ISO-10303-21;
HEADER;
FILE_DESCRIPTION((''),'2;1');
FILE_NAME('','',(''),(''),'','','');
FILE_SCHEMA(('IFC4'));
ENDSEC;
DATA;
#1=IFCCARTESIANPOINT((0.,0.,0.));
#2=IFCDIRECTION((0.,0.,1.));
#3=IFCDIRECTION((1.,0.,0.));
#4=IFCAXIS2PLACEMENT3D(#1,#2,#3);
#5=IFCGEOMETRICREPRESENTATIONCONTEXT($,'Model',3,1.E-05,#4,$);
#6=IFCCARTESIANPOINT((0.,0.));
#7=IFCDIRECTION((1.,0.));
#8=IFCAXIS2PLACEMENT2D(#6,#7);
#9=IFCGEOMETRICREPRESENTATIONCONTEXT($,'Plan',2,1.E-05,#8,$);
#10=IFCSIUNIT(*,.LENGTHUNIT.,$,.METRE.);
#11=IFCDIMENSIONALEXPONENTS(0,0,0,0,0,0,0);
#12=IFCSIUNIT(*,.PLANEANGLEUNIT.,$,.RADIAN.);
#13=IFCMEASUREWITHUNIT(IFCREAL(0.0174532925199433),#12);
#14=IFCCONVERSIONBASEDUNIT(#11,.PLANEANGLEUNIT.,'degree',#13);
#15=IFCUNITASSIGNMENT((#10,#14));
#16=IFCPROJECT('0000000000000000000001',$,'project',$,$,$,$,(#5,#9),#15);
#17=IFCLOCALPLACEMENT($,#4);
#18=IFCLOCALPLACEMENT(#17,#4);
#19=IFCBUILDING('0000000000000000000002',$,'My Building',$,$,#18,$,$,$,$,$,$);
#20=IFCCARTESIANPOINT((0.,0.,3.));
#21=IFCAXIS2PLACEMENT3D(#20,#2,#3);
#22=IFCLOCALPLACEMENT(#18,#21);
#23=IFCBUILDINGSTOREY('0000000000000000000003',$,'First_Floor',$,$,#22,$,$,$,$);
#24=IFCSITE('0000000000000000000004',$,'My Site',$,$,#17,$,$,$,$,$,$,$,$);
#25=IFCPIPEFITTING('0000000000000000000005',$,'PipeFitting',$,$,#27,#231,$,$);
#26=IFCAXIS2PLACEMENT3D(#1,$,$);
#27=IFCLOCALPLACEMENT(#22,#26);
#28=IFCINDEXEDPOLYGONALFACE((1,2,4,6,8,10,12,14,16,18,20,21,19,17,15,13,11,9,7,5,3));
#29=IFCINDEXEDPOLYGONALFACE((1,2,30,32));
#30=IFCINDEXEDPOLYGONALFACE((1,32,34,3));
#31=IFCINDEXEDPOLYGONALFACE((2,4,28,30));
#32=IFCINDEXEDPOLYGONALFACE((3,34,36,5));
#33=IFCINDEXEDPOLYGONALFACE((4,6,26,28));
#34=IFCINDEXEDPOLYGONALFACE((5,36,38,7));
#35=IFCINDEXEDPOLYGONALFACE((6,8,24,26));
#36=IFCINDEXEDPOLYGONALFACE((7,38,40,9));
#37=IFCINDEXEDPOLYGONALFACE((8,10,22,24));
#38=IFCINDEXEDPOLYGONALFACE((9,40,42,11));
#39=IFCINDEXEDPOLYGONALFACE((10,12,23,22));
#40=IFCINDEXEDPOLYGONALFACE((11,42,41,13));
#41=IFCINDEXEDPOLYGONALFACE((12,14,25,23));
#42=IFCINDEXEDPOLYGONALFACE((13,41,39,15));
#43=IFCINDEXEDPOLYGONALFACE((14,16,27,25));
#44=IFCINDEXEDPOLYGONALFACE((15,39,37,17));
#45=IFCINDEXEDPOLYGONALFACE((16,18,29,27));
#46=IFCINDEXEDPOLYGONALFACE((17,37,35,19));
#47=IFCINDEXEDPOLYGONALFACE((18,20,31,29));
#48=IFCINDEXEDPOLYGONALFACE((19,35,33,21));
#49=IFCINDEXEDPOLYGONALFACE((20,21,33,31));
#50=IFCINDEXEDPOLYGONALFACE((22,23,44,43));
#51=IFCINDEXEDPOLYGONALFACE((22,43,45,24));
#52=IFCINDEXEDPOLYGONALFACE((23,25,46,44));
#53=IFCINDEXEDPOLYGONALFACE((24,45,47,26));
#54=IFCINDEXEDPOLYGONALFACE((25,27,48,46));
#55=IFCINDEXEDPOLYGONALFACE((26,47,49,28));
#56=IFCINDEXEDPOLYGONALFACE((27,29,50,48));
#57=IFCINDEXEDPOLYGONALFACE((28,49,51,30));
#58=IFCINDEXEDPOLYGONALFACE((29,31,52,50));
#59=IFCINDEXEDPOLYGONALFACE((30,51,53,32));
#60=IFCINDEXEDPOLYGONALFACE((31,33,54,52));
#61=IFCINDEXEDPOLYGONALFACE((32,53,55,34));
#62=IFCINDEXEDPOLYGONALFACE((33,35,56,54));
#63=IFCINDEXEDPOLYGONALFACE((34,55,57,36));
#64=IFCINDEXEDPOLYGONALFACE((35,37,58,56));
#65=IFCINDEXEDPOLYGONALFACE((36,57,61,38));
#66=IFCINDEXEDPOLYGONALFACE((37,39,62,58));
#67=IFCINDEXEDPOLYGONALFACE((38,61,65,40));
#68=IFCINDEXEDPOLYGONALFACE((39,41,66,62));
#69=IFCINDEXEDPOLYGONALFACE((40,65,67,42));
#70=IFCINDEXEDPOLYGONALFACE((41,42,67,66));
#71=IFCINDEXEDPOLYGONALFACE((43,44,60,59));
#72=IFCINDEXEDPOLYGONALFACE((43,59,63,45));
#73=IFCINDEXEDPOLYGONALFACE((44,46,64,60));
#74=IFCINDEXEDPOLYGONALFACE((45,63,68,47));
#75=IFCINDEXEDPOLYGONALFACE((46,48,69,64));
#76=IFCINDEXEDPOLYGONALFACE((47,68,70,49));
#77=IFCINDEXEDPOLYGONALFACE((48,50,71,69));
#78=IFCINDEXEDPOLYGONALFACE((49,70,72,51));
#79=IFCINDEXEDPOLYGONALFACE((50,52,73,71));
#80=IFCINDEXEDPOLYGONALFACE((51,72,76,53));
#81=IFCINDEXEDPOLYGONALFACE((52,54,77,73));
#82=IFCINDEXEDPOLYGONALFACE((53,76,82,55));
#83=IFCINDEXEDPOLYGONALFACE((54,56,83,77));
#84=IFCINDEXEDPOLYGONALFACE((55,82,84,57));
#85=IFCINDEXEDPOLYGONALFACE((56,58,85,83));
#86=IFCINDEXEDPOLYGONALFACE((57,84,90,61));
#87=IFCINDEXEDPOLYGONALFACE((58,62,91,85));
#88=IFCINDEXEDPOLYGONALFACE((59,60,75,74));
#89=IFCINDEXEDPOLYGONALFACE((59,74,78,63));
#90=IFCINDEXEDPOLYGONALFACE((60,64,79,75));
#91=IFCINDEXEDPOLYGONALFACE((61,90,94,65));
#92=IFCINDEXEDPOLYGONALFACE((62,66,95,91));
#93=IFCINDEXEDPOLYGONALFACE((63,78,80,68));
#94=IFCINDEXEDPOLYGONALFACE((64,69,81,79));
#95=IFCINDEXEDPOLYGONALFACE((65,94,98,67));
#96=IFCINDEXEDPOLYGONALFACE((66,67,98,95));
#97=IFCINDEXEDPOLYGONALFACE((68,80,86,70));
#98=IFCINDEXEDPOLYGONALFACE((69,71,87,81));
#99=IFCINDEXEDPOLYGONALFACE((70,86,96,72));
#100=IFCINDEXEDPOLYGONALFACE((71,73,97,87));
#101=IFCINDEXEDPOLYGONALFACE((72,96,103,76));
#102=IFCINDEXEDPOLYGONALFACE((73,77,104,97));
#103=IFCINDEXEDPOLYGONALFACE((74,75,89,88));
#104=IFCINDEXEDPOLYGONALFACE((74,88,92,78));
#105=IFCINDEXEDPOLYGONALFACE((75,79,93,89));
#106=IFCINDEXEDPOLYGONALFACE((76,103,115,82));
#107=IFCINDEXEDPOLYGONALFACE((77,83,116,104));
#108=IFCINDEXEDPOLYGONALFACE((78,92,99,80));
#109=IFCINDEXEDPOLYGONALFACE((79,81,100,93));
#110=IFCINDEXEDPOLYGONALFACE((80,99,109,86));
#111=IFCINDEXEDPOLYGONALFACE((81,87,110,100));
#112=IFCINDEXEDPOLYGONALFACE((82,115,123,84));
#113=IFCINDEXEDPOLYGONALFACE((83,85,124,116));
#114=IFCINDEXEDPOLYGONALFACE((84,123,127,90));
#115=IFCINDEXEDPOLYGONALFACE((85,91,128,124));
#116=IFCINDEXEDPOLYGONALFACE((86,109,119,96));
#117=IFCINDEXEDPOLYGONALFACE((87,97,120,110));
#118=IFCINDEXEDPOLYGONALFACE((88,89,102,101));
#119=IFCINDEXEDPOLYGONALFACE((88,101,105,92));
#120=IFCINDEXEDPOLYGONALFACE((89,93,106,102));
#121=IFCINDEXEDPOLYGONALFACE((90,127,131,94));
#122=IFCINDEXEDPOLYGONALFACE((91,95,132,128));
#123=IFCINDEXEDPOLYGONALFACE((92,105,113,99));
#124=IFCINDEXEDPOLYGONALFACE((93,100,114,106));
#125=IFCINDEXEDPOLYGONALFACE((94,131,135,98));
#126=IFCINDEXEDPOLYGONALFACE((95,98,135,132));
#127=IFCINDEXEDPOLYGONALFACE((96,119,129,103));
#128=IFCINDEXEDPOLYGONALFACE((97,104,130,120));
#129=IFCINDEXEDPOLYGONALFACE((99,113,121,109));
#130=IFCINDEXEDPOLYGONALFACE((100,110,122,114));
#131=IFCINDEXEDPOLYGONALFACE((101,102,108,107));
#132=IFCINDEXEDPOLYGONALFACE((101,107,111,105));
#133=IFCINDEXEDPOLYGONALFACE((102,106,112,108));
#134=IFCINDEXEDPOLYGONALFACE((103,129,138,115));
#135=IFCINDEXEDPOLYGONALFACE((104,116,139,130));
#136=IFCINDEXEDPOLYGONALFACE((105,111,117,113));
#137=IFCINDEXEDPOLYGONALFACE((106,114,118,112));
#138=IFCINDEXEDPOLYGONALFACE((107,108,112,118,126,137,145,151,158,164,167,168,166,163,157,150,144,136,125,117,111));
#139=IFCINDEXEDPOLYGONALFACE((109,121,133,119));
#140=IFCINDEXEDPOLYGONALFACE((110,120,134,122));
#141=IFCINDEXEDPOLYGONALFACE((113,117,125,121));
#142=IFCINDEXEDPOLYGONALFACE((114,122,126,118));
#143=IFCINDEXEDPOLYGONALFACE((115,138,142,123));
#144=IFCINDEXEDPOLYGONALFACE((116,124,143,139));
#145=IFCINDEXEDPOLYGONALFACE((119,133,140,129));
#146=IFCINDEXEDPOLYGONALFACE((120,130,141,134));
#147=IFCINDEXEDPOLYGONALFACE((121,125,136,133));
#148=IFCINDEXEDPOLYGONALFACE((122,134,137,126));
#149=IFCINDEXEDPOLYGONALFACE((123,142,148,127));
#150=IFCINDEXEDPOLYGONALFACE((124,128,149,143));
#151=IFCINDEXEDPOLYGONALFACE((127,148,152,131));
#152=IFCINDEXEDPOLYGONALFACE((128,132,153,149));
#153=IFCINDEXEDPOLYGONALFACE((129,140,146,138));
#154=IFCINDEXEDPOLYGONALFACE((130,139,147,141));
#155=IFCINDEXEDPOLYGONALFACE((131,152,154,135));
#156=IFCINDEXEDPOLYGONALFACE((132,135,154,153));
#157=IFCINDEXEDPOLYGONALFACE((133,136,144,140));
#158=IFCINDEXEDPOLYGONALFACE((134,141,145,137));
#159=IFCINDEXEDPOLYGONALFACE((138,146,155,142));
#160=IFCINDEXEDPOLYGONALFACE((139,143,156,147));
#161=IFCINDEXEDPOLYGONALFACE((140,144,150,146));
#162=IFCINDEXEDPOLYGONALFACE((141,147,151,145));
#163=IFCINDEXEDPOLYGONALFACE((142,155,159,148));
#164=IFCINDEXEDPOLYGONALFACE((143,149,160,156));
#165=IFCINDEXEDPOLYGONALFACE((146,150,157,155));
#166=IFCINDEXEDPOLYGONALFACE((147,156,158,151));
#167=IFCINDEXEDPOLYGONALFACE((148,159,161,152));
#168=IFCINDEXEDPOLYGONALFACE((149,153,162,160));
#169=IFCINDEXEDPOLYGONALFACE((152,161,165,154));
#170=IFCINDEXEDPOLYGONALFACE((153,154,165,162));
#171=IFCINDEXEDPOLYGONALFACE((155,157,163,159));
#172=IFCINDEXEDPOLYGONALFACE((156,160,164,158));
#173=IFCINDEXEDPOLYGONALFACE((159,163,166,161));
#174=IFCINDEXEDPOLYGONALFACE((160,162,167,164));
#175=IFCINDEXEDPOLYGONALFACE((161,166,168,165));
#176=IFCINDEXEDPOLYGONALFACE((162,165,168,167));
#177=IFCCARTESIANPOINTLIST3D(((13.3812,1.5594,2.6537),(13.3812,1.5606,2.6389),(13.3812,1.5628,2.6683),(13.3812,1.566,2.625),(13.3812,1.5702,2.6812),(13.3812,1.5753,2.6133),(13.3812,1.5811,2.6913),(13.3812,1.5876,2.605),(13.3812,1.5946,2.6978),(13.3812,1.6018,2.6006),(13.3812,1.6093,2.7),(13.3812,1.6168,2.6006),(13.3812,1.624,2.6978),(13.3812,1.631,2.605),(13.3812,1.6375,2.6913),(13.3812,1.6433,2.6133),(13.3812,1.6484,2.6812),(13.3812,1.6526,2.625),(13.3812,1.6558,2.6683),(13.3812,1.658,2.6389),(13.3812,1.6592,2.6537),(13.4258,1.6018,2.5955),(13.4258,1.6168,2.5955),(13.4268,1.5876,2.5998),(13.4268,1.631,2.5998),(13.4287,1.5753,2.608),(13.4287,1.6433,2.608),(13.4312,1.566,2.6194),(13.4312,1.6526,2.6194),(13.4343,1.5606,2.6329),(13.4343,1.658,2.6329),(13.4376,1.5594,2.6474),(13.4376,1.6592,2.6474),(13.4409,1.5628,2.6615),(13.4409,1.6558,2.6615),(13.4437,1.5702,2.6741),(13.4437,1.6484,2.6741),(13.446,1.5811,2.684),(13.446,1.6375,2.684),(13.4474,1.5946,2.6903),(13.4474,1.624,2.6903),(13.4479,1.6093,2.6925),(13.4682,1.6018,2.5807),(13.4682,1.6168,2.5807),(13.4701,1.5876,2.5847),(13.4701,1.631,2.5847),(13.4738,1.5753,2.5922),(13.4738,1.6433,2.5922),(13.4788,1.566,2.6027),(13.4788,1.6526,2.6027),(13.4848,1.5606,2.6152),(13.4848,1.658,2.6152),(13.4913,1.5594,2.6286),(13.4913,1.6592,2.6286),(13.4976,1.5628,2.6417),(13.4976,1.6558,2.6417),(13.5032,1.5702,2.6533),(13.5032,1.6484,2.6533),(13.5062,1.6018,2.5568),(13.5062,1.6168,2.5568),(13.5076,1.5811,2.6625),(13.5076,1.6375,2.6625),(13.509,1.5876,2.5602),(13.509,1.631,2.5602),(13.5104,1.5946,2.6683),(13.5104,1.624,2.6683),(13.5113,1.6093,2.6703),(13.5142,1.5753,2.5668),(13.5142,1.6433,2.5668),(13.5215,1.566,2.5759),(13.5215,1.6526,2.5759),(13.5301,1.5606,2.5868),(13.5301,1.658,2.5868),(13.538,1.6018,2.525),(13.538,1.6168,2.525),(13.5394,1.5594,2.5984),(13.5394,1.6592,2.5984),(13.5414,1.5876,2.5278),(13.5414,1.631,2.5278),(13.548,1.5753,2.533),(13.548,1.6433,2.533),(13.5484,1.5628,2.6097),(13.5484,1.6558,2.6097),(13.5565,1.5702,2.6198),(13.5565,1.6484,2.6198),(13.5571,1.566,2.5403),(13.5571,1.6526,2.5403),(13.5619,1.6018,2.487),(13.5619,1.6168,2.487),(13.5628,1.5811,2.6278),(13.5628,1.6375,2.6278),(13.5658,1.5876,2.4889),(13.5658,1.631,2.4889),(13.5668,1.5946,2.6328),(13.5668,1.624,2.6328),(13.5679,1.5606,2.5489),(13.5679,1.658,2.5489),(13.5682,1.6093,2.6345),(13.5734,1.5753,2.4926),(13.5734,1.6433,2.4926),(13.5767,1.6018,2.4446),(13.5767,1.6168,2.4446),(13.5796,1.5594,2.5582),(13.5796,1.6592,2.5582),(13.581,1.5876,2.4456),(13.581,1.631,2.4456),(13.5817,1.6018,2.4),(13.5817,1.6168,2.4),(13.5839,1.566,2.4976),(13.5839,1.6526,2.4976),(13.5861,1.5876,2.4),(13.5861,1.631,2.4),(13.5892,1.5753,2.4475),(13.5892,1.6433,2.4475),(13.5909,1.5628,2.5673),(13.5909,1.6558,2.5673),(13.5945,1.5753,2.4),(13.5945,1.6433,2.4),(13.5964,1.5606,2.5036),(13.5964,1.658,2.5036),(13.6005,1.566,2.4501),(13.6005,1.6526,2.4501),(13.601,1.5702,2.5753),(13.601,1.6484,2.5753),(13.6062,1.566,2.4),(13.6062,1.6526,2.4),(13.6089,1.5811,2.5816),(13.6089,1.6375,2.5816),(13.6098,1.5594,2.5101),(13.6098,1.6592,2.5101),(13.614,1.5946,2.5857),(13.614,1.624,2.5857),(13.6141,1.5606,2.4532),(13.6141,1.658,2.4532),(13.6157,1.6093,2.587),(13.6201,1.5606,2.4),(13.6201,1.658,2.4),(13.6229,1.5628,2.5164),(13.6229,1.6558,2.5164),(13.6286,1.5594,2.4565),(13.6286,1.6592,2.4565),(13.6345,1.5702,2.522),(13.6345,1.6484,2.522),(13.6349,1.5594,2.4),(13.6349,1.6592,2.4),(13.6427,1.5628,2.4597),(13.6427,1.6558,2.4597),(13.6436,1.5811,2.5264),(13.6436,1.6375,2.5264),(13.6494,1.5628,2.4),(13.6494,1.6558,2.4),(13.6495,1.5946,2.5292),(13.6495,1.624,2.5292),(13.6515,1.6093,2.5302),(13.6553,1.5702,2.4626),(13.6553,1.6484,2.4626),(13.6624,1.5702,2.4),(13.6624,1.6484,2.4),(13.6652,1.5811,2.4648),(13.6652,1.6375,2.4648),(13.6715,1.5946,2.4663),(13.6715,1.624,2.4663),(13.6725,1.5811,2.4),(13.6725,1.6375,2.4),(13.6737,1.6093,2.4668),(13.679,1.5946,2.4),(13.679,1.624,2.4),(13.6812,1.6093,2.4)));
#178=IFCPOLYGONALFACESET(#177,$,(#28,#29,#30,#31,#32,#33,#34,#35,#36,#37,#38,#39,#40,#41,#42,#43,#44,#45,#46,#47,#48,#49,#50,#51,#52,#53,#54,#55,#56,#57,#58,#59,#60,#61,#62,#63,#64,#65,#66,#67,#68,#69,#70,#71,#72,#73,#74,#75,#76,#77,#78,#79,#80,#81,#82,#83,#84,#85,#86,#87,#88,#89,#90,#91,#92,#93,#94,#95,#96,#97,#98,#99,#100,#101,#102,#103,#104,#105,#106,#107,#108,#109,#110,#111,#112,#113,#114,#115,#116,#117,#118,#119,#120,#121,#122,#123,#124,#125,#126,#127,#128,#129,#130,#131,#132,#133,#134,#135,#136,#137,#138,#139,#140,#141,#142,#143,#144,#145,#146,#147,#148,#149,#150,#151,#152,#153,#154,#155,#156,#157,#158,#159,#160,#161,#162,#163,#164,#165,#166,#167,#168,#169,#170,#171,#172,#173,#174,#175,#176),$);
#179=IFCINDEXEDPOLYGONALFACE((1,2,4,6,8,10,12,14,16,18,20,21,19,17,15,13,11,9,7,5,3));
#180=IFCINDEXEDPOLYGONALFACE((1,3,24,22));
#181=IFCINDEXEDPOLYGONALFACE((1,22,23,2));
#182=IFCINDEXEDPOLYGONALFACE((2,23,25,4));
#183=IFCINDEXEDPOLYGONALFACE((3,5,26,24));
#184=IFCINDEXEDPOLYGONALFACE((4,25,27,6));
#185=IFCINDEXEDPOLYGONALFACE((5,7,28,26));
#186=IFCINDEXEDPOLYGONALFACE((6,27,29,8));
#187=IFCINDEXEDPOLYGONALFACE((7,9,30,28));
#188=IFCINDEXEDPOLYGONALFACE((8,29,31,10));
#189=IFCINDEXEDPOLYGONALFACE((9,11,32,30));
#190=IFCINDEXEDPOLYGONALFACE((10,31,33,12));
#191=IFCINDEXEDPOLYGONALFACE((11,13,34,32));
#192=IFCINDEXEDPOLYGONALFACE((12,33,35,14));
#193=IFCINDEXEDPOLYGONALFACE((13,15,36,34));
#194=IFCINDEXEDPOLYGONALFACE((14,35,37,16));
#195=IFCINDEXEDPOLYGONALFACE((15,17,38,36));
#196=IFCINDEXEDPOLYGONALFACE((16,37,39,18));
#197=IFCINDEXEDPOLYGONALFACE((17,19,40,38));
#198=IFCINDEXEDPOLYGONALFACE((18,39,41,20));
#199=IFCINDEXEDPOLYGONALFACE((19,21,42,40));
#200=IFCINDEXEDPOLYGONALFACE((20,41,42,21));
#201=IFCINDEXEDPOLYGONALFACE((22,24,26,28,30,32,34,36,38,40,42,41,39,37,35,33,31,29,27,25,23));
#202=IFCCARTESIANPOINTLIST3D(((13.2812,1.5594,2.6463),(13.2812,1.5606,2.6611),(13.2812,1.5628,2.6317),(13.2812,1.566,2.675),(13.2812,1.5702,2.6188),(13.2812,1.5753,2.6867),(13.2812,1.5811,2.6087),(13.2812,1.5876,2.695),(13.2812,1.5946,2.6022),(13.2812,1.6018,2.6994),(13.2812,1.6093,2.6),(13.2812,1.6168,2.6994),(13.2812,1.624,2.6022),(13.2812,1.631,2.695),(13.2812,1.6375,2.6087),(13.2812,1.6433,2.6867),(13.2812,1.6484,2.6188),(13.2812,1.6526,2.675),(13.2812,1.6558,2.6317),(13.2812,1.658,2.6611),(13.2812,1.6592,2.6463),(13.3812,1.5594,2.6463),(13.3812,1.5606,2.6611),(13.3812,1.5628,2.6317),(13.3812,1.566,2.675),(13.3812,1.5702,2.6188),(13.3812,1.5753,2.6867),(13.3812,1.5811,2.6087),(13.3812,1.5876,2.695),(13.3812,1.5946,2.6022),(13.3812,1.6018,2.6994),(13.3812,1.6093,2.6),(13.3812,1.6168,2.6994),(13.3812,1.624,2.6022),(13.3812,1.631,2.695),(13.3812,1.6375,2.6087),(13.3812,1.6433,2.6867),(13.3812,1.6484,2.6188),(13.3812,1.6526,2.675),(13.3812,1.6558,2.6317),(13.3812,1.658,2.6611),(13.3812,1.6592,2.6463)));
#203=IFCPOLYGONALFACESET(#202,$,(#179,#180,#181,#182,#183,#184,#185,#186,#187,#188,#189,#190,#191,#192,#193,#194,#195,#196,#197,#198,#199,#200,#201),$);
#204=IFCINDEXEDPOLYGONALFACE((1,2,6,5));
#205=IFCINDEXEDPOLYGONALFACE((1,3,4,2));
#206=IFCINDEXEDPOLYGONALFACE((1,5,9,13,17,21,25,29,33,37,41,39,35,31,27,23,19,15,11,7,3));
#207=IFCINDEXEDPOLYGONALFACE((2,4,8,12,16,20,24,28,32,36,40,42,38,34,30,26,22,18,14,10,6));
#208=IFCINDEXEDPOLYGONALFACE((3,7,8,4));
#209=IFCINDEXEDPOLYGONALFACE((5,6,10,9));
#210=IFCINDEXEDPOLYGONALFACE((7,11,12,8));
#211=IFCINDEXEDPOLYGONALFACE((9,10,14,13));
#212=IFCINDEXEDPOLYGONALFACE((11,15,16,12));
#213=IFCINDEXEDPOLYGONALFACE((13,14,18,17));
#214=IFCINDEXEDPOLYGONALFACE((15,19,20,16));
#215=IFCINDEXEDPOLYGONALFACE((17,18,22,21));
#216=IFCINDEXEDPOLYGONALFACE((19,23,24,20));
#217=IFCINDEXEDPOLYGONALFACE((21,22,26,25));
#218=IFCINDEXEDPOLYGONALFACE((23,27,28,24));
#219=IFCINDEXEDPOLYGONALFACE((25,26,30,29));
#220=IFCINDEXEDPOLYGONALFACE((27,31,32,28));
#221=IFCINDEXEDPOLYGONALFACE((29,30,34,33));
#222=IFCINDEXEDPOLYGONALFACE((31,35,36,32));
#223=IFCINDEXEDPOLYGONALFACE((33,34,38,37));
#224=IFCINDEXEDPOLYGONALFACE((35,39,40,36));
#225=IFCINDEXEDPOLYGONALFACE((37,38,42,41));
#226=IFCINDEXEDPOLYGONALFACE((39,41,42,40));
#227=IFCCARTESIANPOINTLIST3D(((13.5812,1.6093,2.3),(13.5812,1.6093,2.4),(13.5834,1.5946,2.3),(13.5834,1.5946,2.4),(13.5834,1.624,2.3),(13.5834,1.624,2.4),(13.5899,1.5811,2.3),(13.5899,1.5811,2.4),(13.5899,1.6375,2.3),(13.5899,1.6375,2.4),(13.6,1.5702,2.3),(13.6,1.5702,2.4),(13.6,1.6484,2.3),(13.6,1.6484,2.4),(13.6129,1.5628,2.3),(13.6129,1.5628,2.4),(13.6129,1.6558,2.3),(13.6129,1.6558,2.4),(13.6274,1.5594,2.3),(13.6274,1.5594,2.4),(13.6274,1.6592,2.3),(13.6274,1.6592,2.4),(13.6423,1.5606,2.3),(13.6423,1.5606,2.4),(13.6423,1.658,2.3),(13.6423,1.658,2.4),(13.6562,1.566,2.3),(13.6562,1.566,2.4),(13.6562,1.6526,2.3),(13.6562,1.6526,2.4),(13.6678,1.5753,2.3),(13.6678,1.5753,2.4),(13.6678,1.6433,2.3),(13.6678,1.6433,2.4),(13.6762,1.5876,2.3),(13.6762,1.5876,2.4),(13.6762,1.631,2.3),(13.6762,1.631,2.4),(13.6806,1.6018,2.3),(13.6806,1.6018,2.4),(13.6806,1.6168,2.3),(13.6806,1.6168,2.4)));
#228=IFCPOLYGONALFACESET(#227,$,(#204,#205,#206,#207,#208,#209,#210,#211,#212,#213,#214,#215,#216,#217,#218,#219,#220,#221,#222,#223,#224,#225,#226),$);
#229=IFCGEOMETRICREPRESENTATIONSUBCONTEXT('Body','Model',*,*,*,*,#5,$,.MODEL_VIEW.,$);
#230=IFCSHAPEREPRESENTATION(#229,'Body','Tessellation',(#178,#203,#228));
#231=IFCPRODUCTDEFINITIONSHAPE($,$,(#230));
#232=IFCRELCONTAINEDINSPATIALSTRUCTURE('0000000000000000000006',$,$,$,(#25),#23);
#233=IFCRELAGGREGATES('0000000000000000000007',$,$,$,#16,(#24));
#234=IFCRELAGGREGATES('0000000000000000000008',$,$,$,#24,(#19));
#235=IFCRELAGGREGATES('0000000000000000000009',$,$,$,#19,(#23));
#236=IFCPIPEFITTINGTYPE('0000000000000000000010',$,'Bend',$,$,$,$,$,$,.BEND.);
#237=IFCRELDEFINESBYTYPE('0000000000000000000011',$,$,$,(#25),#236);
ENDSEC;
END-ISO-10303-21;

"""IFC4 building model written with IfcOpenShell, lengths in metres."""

from ifc_helpers import new_model, entity, si_unit, converted_unit, frame, origin_with_axes, origin_2d_with_axis, place, context, subcontext, project, spatial, circle, extrude, source, transform, mapped, type_object, type_shapes, element, save


model = new_model("IFC4")

# Units and contexts
model_context = context("Model", 3, precision=1e-05, world=origin_with_axes())
plan_context = context("Plan", 2, precision=1e-05, world=origin_2d_with_axis())
body_context = subcontext(model_context, "Body", "Model", "MODEL_VIEW")
ifc_project = project(units=[si_unit("LENGTHUNIT", "METRE"), converted_unit("PLANEANGLEUNIT", "degree", entity("IfcReal", 0.0174532925199433), si_unit("PLANEANGLEUNIT", "RADIAN"), dimensions=[0, 0, 0, 0, 0, 0, 0])], contexts=[model_context, plan_context])

# Site, building, storey
site_placement = place(None, origin_with_axes())
site = spatial("IfcSite", under=ifc_project, at=site_placement, Name="My Site")
building_placement = place(site_placement, origin_with_axes())
building = spatial("IfcBuilding", under=site, at=building_placement, Name="My Building")
storey_placement = place(building_placement, frame((0.0, 0.0, 3.0), z_axis=(0.0, 0.0, 1.0), x_axis=(1.0, 0.0, 0.0)))
storey = spatial("IfcBuildingStorey", under=building, at=storey_placement, Name="First_Floor")

# Pipe fitting
pipe_fitting_type = type_object("IfcPipeFittingType", Name="Bend", PredefinedType="BEND")
shared_shape_1 = source(origin_with_axes(), body_context, "Body", "SolidModel", [
    entity("IfcSweptDiskSolid", entity("IfcIndexedPolyCurve", entity("IfcCartesianPointList3D", [[0.0, 0.0, -0.1], [0.0732, 0.0, -0.2768], [0.25, 0.0, -0.35]]), [entity("IfcArcIndex", [1, 2, 3])]), 0.05),
    extrude(circle(Radius=0.05), origin_with_axes(), (0.0, 0.0, -1.0), 0.1),
    extrude(circle(Radius=0.05), frame((0.25, 0.0, -0.35), z_axis=(1.0, 0.0, 0.0), x_axis=(0.0, 0.0, 1.0)), (0.0, 0.0, 1.0), 0.1),
])
type_shapes(pipe_fitting_type, [shared_shape_1])
for number, where, z_axis, x_axis, name in (
    (1, (13.2812, 1.6093, 2.65), (-1.0, 0.0, 0.0), (0.0, 0.0, -1.0), "PipeFitting"),
):
    element("IfcPipeFitting", number, at=place(storey_placement, frame(where, z_axis=z_axis, x_axis=x_axis)), inside=storey, type_object=pipe_fitting_type, Name=name, context=body_context, shape_type="MappedRepresentation", body=[
        mapped(shared_shape_1, transform((0.0, 0.0, 0.0), x_axis=(1.0, 0.0, 0.0), y_axis=(0.0, 1.0, 0.0), z_axis=(0.0, 0.0, 1.0), scale=1.0)),
    ])

save(model, "model.ifc")
